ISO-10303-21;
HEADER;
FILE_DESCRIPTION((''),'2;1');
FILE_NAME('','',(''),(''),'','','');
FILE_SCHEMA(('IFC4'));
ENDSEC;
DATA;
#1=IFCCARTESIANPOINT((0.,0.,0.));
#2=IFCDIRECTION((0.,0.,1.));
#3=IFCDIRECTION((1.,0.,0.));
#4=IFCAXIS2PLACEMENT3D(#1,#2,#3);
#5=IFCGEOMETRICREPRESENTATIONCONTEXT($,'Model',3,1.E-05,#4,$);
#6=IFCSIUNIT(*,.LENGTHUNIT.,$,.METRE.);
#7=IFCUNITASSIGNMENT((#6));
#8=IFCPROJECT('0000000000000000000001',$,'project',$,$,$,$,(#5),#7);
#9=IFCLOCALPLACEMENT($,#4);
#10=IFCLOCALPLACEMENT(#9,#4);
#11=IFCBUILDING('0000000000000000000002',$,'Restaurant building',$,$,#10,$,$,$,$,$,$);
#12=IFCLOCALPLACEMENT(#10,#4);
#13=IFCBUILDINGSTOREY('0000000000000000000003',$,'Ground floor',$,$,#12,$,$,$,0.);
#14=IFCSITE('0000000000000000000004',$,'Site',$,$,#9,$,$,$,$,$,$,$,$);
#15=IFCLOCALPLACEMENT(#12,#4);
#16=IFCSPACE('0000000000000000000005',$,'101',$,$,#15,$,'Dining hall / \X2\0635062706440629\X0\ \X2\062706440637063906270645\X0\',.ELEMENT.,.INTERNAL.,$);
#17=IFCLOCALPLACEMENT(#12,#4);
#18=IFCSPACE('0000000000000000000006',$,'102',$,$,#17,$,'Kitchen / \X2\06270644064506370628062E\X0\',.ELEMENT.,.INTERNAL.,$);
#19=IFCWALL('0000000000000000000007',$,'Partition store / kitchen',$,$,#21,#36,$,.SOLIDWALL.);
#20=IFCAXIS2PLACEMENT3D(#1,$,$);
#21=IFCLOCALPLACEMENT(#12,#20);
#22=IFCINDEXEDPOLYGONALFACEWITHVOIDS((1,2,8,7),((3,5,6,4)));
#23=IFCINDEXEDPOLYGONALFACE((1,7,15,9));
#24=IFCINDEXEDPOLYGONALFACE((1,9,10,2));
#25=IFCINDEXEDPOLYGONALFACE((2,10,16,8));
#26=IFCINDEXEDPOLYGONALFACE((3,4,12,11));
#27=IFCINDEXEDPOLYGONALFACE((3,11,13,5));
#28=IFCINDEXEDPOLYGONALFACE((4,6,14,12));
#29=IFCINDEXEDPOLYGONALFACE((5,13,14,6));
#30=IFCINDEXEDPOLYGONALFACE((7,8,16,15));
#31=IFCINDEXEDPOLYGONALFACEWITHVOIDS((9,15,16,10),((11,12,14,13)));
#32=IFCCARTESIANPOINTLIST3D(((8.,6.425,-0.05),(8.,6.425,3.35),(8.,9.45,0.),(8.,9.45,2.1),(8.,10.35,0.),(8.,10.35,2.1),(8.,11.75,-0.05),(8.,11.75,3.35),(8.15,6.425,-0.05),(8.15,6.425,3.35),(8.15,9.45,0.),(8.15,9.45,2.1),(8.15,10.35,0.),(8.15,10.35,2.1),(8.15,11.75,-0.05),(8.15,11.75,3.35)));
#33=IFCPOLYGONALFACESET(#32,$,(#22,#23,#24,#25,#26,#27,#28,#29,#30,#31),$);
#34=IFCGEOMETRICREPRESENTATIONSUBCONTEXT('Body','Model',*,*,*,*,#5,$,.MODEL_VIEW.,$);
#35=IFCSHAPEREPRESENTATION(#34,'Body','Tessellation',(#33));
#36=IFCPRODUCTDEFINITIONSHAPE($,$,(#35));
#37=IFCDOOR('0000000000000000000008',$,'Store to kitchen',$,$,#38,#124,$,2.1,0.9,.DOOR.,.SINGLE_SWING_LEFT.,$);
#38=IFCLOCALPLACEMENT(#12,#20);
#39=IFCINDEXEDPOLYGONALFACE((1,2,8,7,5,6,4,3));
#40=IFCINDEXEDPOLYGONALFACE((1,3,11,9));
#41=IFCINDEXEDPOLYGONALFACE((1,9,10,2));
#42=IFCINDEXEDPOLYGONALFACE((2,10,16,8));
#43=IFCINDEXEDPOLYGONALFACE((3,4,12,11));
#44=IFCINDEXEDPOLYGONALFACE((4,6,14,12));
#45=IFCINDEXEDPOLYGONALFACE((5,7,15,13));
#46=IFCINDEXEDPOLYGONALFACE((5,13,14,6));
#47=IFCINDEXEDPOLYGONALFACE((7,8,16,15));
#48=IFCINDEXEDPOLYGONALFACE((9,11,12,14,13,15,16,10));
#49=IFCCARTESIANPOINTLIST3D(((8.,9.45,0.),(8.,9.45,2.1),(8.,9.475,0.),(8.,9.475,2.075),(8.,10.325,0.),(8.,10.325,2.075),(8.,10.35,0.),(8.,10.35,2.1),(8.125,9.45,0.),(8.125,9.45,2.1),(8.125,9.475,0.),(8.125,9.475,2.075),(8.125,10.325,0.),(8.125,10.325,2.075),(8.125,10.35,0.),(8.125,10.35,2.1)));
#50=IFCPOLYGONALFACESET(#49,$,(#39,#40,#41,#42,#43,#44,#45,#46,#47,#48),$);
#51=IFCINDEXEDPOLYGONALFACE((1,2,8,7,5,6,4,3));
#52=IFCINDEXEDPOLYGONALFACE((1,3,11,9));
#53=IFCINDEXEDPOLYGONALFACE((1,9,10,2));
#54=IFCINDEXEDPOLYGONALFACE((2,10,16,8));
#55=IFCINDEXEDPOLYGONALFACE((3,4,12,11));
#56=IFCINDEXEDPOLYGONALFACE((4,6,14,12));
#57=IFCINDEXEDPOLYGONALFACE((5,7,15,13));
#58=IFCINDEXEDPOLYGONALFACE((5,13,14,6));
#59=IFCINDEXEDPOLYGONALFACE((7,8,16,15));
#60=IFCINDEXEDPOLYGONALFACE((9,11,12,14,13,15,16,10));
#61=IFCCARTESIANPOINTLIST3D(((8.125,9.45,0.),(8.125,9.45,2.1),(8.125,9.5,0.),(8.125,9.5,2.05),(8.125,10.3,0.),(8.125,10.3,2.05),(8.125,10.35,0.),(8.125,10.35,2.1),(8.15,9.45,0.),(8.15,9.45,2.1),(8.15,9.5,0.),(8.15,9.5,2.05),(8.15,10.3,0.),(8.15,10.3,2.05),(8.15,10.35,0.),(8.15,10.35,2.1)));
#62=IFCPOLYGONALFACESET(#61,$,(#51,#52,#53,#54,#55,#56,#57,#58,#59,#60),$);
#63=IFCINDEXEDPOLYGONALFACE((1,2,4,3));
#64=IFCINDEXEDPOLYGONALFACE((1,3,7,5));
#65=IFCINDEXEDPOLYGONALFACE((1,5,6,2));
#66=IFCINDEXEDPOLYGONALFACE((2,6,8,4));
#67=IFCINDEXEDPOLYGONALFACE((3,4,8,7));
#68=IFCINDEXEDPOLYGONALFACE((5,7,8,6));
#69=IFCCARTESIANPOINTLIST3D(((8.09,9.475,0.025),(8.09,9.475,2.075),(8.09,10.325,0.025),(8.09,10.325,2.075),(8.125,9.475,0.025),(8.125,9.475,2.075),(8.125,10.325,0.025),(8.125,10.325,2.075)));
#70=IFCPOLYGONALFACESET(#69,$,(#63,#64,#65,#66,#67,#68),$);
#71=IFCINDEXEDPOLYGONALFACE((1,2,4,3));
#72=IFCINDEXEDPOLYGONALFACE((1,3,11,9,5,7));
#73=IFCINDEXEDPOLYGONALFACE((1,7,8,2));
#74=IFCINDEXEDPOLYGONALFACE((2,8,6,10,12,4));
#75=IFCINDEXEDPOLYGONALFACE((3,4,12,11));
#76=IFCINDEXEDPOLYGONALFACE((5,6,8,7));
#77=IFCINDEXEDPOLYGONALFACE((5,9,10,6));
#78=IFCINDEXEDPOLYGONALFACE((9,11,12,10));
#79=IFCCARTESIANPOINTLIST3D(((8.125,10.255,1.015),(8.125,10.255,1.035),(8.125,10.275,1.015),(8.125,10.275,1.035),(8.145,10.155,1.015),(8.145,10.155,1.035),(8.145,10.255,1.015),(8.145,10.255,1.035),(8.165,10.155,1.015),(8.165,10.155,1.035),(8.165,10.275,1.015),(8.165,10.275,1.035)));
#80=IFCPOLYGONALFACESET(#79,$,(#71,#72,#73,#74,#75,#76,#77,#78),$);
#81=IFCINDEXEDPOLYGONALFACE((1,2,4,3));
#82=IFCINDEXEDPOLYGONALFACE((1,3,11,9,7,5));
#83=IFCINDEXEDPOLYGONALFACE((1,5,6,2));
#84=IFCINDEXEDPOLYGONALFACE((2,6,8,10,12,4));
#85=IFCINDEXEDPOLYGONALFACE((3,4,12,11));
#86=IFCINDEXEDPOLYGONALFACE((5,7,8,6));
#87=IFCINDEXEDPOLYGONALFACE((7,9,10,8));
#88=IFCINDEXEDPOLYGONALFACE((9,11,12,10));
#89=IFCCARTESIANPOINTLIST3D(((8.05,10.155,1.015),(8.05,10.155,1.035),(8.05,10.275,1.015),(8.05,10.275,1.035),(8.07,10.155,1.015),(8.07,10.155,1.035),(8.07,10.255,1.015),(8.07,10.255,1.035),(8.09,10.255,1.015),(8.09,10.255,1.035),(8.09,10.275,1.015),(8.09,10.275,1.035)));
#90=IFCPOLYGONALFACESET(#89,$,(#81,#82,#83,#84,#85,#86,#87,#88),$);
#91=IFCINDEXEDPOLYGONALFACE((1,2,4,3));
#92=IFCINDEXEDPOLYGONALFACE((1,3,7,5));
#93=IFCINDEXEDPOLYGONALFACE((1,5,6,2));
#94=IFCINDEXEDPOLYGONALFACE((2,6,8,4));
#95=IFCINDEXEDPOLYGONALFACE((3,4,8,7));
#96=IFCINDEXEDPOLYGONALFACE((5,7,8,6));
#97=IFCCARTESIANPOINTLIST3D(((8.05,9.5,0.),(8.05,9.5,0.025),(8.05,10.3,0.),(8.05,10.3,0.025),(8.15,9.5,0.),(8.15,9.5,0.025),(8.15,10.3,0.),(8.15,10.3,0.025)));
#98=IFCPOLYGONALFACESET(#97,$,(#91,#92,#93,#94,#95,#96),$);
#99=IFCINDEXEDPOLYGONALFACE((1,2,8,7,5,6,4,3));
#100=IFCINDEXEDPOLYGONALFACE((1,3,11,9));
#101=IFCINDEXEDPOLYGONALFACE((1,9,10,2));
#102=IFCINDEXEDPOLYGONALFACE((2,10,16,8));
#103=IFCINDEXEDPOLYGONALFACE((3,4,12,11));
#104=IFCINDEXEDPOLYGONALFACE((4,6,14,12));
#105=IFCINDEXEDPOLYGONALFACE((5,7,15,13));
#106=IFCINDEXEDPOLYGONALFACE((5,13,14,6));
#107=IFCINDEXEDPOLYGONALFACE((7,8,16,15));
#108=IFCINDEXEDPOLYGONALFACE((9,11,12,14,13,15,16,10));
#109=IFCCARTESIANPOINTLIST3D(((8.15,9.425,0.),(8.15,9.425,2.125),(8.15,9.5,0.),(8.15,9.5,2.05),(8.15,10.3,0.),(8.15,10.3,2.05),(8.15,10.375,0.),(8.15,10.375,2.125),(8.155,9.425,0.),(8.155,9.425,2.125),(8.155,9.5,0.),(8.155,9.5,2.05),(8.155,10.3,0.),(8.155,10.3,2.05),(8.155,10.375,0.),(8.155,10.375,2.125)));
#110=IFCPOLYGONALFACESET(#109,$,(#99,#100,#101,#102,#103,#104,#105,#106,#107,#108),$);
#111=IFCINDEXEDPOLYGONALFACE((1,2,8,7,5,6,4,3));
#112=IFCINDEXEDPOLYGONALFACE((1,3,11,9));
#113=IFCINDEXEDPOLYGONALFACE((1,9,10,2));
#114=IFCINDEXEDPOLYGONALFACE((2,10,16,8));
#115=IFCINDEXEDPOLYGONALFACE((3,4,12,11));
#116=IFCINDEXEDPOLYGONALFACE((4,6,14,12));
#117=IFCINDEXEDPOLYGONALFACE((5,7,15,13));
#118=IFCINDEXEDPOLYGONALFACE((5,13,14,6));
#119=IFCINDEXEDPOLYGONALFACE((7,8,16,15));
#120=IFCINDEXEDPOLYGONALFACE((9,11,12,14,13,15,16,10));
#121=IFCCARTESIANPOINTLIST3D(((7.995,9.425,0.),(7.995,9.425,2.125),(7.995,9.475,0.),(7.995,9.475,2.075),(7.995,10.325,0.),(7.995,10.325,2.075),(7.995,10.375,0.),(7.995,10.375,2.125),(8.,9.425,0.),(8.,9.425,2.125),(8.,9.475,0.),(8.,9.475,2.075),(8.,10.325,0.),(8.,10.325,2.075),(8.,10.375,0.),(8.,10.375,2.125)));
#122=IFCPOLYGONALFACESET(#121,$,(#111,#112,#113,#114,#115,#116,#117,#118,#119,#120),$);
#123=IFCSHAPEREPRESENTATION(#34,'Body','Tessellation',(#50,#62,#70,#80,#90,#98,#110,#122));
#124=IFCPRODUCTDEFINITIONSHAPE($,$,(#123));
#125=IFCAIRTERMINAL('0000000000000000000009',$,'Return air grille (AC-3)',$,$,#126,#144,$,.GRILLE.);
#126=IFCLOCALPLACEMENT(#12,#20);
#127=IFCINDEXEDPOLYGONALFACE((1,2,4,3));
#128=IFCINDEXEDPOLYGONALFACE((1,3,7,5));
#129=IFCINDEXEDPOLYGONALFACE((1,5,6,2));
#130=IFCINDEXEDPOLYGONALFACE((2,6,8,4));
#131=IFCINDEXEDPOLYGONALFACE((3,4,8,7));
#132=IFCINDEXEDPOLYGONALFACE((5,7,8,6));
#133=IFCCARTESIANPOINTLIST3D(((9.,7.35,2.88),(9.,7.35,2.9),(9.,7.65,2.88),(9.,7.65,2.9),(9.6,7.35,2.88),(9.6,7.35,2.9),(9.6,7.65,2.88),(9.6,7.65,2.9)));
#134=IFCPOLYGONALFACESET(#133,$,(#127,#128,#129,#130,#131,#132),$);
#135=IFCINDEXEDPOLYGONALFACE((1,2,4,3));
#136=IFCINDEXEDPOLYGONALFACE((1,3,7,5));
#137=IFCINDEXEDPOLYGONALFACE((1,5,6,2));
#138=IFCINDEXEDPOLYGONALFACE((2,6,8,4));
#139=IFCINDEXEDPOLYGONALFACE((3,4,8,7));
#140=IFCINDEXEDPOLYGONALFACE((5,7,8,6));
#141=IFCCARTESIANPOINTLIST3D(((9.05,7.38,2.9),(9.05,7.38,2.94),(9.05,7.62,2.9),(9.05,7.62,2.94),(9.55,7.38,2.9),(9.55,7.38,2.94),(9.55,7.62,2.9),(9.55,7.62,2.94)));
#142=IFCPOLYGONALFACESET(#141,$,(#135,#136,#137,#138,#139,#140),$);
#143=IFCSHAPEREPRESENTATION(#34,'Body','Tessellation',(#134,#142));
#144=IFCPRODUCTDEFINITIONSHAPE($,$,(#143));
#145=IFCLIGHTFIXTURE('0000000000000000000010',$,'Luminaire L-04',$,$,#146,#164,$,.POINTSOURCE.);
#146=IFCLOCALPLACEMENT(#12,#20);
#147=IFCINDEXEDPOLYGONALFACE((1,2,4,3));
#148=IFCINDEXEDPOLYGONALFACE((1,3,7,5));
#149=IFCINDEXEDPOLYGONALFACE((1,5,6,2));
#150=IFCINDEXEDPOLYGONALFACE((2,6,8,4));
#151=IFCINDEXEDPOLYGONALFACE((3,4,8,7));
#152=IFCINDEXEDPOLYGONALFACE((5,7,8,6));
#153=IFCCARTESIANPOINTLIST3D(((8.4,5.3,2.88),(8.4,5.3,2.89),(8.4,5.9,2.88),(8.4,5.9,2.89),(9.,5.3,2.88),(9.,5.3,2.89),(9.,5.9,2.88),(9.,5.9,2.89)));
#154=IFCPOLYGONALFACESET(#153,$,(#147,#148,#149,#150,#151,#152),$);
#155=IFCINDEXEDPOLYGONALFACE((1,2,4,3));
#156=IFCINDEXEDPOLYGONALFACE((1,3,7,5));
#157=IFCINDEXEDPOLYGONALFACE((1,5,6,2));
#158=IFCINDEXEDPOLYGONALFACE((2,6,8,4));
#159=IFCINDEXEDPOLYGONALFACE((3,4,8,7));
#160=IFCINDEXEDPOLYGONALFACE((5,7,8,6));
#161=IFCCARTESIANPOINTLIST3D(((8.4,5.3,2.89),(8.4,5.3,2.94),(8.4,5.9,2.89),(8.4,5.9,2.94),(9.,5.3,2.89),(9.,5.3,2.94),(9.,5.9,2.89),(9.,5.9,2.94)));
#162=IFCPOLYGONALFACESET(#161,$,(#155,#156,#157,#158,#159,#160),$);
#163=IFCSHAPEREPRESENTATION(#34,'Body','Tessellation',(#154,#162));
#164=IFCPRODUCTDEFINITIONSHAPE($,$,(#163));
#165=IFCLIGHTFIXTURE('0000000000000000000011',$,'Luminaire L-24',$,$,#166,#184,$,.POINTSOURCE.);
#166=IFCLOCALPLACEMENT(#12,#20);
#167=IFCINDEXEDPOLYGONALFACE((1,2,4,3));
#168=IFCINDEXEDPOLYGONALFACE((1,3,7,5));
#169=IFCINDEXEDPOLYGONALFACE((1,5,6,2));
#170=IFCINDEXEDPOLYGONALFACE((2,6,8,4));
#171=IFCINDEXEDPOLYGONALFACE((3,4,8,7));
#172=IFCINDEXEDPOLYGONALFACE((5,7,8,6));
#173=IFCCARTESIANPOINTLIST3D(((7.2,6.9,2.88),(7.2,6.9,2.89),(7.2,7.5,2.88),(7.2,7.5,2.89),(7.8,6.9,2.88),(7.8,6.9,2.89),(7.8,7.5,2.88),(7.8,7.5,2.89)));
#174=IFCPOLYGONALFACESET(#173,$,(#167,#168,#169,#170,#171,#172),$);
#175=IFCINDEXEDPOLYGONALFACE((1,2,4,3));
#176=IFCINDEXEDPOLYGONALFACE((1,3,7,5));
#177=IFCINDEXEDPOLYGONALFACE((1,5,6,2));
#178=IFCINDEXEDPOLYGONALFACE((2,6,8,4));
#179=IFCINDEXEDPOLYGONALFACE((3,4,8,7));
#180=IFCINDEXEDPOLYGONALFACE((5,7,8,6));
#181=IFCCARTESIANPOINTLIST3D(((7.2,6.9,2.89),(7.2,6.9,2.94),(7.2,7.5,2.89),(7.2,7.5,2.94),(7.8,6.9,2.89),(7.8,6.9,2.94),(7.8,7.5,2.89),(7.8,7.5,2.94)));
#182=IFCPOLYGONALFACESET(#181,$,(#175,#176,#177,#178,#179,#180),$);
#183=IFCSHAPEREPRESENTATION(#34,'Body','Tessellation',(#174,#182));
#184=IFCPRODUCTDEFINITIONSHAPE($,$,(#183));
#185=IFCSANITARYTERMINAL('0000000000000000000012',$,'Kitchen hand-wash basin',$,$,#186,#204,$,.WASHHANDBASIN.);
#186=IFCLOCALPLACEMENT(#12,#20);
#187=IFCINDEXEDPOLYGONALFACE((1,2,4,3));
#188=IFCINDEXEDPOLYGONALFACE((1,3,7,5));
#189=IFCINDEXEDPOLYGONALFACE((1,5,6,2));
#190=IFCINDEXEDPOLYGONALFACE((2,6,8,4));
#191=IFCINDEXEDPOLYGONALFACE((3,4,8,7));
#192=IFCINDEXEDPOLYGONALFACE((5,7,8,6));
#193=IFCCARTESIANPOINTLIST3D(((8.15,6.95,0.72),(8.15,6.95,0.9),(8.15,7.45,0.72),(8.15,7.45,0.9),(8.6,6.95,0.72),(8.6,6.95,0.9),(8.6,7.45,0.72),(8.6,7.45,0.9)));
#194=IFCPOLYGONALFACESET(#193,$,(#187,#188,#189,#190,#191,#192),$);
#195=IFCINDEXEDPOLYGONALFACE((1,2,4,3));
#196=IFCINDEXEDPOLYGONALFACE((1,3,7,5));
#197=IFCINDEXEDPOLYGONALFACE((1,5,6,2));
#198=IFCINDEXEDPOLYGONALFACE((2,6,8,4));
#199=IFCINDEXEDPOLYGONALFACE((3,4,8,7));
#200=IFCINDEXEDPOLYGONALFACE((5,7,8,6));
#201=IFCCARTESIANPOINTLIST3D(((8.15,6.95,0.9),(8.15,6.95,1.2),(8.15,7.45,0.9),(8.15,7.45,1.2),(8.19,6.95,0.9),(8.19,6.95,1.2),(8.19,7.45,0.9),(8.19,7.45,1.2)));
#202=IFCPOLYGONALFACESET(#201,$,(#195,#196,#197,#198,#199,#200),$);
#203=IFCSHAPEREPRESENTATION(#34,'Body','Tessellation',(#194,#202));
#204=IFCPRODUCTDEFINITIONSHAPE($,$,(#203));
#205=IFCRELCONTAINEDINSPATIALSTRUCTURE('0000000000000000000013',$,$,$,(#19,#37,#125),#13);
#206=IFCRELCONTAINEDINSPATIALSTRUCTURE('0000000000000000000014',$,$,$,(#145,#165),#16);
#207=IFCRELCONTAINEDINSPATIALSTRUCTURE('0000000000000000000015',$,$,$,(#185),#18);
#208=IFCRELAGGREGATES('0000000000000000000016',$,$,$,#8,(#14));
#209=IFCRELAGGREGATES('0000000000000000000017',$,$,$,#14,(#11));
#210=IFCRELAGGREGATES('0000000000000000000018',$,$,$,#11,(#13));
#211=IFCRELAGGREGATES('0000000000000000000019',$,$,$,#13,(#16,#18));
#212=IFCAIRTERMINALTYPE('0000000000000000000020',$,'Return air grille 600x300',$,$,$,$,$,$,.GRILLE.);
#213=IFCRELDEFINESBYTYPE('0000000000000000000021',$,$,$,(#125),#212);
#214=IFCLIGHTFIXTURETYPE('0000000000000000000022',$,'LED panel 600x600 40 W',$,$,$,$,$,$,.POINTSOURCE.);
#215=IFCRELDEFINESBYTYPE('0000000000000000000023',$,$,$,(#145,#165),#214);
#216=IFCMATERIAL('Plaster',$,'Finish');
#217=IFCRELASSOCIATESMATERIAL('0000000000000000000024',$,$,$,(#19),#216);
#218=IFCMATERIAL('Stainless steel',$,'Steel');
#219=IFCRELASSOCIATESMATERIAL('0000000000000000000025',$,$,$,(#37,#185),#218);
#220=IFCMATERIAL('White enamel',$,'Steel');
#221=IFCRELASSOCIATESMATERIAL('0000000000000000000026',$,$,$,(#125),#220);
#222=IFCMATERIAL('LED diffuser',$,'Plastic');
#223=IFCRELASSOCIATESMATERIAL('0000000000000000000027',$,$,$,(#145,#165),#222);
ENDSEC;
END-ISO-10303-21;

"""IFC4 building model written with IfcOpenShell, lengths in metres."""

from ifc_helpers import new_model, si_unit, frame, origin, origin_with_axes, origin_2d, place, context, subcontext, project, spatial, line, indexed_curve, rectangle, outline, extrude, source, transform, mapped, material, type_object, type_shapes, element, fill, save


model = new_model("IFC4")

# Units and contexts
model_context = context("Model", 3, precision=1e-05, world=origin_with_axes())
body_context = subcontext(model_context, "Body", "Model", "MODEL_VIEW")
ifc_project = project(units=[si_unit("LENGTHUNIT", "METRE")], contexts=[model_context])

# Site, building, storey
site_placement = place(None, origin_with_axes())
site = spatial("IfcSite", under=ifc_project, at=site_placement, Name="Site")
building_placement = place(site_placement, origin_with_axes())
building = spatial("IfcBuilding", under=site, at=building_placement, Name="Restaurant building")
storey_placement = place(building_placement, origin_with_axes())
storey = spatial("IfcBuildingStorey", under=building, at=storey_placement, Name="Ground floor", Elevation=0.0)

# Shared definitions
ifc_material_1 = material(Name="Plaster", Category="Finish")
ifc_material_2 = material(Name="Stainless steel", Category="Steel")

# Wall, opening, door
wall_1_placement = place(storey_placement, frame((8.075, 6.425, 0.0), z_axis=(0.0, 0.0, 1.0), x_axis=(0.0, 1.0, 0.0)))
wall_1 = element("IfcWall", 1, at=wall_1_placement, inside=storey, material=ifc_material_1, Name="Partition store / kitchen", PredefinedType="SOLIDWALL", context=body_context, shape_type="SweptSolid", body=[
    extrude(rectangle(XDim=5.325, YDim=0.15, at=origin_2d()), frame((2.6625, 0.0, -0.05)), (0.0, 0.0, 1.0), 3.4),
])
opening_1_placement = place(wall_1_placement, frame((3.025, -0.075, 0.0), z_axis=(0.0, 0.0, 1.0), x_axis=(1.0, 0.0, 0.0)))
opening_1 = element("IfcOpeningElement", 2, at=opening_1_placement, cuts=wall_1, PredefinedType="OPENING", context=body_context, shape_type="SweptSolid", body=[
    extrude(rectangle(XDim=0.9, YDim=0.25, at=origin_2d()), frame((0.45, 0.075, 0.0)), (0.0, 0.0, 1.0), 2.1),
])
door_1_placement = place(storey_placement, frame((8.15, 9.45, 0.0), z_axis=(0.0, 0.0, 1.0), x_axis=(0.0, 1.0, 0.0)))
door_1 = element("IfcDoor", 3, at=door_1_placement, inside=storey, material=ifc_material_2, Name="Store to kitchen", OperationType="SINGLE_SWING_LEFT", OverallHeight=2.1, OverallWidth=0.9, PredefinedType="DOOR", context=body_context, shape_type="SweptSolid", body=[
    extrude(outline(indexed_curve([(0.0, 0.0), (0.0, 2.1), (0.9, 2.1), (0.9, 0.0), (0.875, 0.0), (0.875, 2.075), (0.025, 2.075), (0.025, 0.0)], segments=[line(1, 2, 3, 4, 5, 6, 7, 8, 1)])), frame((0.0, 0.025, 0.0), z_axis=(0.0, -1.0, 0.0), x_axis=(1.0, 0.0, 0.0)), (0.0, 0.0, -1.0), 0.125),
    extrude(outline(indexed_curve([(0.0, 0.0), (0.0, 2.1), (0.9, 2.1), (0.9, 0.0), (0.85, 0.0), (0.85, 2.05), (0.05, 2.05), (0.05, 0.0)], segments=[line(1, 2, 3, 4, 5, 6, 7, 8, 1)])), frame((0.0, 0.0, 0.0), z_axis=(0.0, -1.0, 0.0), x_axis=(1.0, 0.0, 0.0)), (0.0, 0.0, -1.0), 0.025),
    extrude(outline(indexed_curve([(0.0, 0.0), (0.85, 0.0), (0.85, 0.035), (0.0, 0.035)], segments=[line(1, 2, 3, 4, 1)])), frame((0.025, 0.025, 0.025), z_axis=(0.0, 0.0, 1.0), x_axis=(1.0, 0.0, 0.0)), (0.0, 0.0, 1.0), 2.05),
    extrude(outline(indexed_curve([(0.0, 0.0), (0.0, -0.04), (-0.12, -0.04), (-0.12, -0.02), (-0.02, -0.02), (-0.02, 0.0)], segments=[line(1, 2, 3, 4, 5, 6, 1)])), frame((0.825, 0.025, 1.015), z_axis=(0.0, 0.0, 1.0), x_axis=(1.0, 0.0, 0.0)), (0.0, 0.0, 1.0), 0.02),
    extrude(outline(indexed_curve([(0.0, 0.0), (0.0, 0.04), (-0.12, 0.04), (-0.12, 0.02), (-0.02, 0.02), (-0.02, 0.0)], segments=[line(1, 2, 3, 4, 5, 6, 1)])), frame((0.825, 0.06, 1.015), z_axis=(0.0, 0.0, 1.0), x_axis=(1.0, 0.0, 0.0)), (0.0, 0.0, 1.0), 0.02),
    extrude(outline(indexed_curve([(0.0, 0.0), (0.8, 0.0), (0.8, 0.1), (0.0, 0.1)], segments=[line(1, 2, 3, 4, 1)])), frame((0.05, 0.0, 0.0), z_axis=(0.0, 0.0, 1.0), x_axis=(1.0, 0.0, 0.0)), (0.0, 0.0, 1.0), 0.025),
    extrude(outline(indexed_curve([(0.0, 0.0), (0.0, 2.125), (0.95, 2.125), (0.95, 0.0), (0.875, 0.0), (0.875, 2.05), (0.075, 2.05), (0.075, 0.0)], segments=[line(1, 2, 3, 4, 5, 6, 7, 8, 1)])), frame((-0.025, -0.005, 0.0), z_axis=(0.0, -1.0, 0.0), x_axis=(1.0, 0.0, 0.0)), (0.0, 0.0, -1.0), 0.005),
    extrude(outline(indexed_curve([(0.0, 0.0), (0.0, 2.125), (0.95, 2.125), (0.95, 0.0), (0.9, 0.0), (0.9, 2.075), (0.05, 2.075), (0.05, 0.0)], segments=[line(1, 2, 3, 4, 5, 6, 7, 8, 1)])), frame((-0.025, 0.15, 0.0), z_axis=(0.0, -1.0, 0.0), x_axis=(1.0, 0.0, 0.0)), (0.0, 0.0, -1.0), 0.005),
])
fill(opening_1, door_1)

# Air terminal
ifc_material_3 = material(Name="White enamel", Category="Steel")
air_terminal_type = type_object("IfcAirTerminalType", Name="Return air grille 600x300", PredefinedType="GRILLE")
shared_shape_1 = source(origin(), body_context, "Body", "SweptSolid", [
    extrude(rectangle(XDim=0.6, YDim=0.3, at=origin_2d()), frame((0.0, 0.0, -0.06)), (0.0, 0.0, 1.0), 0.02),
    extrude(rectangle(XDim=0.5, YDim=0.24, at=origin_2d()), frame((0.0, 0.0, -0.04)), (0.0, 0.0, 1.0), 0.04),
])
type_shapes(air_terminal_type, [shared_shape_1])
air_terminal_placement = place(storey_placement, frame((9.3, 7.5, 2.94)))
element("IfcAirTerminal", 4, at=air_terminal_placement, inside=storey, type_object=air_terminal_type, material=ifc_material_3, Name="Return air grille (AC-3)", PredefinedType="GRILLE", context=body_context, shape_type="MappedRepresentation", body=[
    mapped(shared_shape_1, transform((0.0, 0.0, 0.0))),
])

# Shared definitions
space_1_placement = place(storey_placement, origin_with_axes())
space_1 = spatial("IfcSpace", under=storey, at=space_1_placement, Name="101", LongName="Dining hall / صالة الطعام", CompositionType="ELEMENT", PredefinedType="INTERNAL")

# Light fixtures
ifc_material_4 = material(Name="LED diffuser", Category="Plastic")
light_fixture_type = type_object("IfcLightFixtureType", Name="LED panel 600x600 40 W", PredefinedType="POINTSOURCE")
shared_shape_2 = source(origin(), body_context, "Body", "SweptSolid", [
    extrude(rectangle(XDim=0.6, YDim=0.6, at=origin_2d()), frame((0.0, 0.0, -0.06)), (0.0, 0.0, 1.0), 0.01),
    extrude(rectangle(XDim=0.6, YDim=0.6, at=origin_2d()), frame((0.0, 0.0, -0.05)), (0.0, 0.0, 1.0), 0.05),
])
type_shapes(light_fixture_type, [shared_shape_2])
for number, where, name in (
    (5, (8.7, 5.6, 2.94), "Luminaire L-04"),
    (6, (7.5, 7.2, 2.94), "Luminaire L-24"),
):
    element("IfcLightFixture", number, at=place(storey_placement, frame(where)), inside=space_1, type_object=light_fixture_type, material=ifc_material_4, Name=name, PredefinedType="POINTSOURCE", context=body_context, shape_type="MappedRepresentation", body=[
        mapped(shared_shape_2, transform((0.0, 0.0, 0.0))),
    ])

# Shared definitions
space_2_placement = place(storey_placement, origin_with_axes())
space_2 = spatial("IfcSpace", under=storey, at=space_2_placement, Name="102", LongName="Kitchen / المطبخ", CompositionType="ELEMENT", PredefinedType="INTERNAL")

# Sanitary terminal
sanitary_terminal_placement = place(storey_placement, frame((8.15, 6.95, 0.0)))
element("IfcSanitaryTerminal", 7, at=sanitary_terminal_placement, inside=space_2, material=ifc_material_2, Name="Kitchen hand-wash basin", PredefinedType="WASHHANDBASIN", context=body_context, shape_type="SweptSolid", body=[
    extrude(rectangle(XDim=0.45, YDim=0.5, at=origin_2d()), frame((0.225, 0.25, 0.72)), (0.0, 0.0, 1.0), 0.18),
    extrude(rectangle(XDim=0.04, YDim=0.5, at=origin_2d()), frame((0.02, 0.25, 0.9)), (0.0, 0.0, 1.0), 0.3),
])

save(model, "model.ifc")
